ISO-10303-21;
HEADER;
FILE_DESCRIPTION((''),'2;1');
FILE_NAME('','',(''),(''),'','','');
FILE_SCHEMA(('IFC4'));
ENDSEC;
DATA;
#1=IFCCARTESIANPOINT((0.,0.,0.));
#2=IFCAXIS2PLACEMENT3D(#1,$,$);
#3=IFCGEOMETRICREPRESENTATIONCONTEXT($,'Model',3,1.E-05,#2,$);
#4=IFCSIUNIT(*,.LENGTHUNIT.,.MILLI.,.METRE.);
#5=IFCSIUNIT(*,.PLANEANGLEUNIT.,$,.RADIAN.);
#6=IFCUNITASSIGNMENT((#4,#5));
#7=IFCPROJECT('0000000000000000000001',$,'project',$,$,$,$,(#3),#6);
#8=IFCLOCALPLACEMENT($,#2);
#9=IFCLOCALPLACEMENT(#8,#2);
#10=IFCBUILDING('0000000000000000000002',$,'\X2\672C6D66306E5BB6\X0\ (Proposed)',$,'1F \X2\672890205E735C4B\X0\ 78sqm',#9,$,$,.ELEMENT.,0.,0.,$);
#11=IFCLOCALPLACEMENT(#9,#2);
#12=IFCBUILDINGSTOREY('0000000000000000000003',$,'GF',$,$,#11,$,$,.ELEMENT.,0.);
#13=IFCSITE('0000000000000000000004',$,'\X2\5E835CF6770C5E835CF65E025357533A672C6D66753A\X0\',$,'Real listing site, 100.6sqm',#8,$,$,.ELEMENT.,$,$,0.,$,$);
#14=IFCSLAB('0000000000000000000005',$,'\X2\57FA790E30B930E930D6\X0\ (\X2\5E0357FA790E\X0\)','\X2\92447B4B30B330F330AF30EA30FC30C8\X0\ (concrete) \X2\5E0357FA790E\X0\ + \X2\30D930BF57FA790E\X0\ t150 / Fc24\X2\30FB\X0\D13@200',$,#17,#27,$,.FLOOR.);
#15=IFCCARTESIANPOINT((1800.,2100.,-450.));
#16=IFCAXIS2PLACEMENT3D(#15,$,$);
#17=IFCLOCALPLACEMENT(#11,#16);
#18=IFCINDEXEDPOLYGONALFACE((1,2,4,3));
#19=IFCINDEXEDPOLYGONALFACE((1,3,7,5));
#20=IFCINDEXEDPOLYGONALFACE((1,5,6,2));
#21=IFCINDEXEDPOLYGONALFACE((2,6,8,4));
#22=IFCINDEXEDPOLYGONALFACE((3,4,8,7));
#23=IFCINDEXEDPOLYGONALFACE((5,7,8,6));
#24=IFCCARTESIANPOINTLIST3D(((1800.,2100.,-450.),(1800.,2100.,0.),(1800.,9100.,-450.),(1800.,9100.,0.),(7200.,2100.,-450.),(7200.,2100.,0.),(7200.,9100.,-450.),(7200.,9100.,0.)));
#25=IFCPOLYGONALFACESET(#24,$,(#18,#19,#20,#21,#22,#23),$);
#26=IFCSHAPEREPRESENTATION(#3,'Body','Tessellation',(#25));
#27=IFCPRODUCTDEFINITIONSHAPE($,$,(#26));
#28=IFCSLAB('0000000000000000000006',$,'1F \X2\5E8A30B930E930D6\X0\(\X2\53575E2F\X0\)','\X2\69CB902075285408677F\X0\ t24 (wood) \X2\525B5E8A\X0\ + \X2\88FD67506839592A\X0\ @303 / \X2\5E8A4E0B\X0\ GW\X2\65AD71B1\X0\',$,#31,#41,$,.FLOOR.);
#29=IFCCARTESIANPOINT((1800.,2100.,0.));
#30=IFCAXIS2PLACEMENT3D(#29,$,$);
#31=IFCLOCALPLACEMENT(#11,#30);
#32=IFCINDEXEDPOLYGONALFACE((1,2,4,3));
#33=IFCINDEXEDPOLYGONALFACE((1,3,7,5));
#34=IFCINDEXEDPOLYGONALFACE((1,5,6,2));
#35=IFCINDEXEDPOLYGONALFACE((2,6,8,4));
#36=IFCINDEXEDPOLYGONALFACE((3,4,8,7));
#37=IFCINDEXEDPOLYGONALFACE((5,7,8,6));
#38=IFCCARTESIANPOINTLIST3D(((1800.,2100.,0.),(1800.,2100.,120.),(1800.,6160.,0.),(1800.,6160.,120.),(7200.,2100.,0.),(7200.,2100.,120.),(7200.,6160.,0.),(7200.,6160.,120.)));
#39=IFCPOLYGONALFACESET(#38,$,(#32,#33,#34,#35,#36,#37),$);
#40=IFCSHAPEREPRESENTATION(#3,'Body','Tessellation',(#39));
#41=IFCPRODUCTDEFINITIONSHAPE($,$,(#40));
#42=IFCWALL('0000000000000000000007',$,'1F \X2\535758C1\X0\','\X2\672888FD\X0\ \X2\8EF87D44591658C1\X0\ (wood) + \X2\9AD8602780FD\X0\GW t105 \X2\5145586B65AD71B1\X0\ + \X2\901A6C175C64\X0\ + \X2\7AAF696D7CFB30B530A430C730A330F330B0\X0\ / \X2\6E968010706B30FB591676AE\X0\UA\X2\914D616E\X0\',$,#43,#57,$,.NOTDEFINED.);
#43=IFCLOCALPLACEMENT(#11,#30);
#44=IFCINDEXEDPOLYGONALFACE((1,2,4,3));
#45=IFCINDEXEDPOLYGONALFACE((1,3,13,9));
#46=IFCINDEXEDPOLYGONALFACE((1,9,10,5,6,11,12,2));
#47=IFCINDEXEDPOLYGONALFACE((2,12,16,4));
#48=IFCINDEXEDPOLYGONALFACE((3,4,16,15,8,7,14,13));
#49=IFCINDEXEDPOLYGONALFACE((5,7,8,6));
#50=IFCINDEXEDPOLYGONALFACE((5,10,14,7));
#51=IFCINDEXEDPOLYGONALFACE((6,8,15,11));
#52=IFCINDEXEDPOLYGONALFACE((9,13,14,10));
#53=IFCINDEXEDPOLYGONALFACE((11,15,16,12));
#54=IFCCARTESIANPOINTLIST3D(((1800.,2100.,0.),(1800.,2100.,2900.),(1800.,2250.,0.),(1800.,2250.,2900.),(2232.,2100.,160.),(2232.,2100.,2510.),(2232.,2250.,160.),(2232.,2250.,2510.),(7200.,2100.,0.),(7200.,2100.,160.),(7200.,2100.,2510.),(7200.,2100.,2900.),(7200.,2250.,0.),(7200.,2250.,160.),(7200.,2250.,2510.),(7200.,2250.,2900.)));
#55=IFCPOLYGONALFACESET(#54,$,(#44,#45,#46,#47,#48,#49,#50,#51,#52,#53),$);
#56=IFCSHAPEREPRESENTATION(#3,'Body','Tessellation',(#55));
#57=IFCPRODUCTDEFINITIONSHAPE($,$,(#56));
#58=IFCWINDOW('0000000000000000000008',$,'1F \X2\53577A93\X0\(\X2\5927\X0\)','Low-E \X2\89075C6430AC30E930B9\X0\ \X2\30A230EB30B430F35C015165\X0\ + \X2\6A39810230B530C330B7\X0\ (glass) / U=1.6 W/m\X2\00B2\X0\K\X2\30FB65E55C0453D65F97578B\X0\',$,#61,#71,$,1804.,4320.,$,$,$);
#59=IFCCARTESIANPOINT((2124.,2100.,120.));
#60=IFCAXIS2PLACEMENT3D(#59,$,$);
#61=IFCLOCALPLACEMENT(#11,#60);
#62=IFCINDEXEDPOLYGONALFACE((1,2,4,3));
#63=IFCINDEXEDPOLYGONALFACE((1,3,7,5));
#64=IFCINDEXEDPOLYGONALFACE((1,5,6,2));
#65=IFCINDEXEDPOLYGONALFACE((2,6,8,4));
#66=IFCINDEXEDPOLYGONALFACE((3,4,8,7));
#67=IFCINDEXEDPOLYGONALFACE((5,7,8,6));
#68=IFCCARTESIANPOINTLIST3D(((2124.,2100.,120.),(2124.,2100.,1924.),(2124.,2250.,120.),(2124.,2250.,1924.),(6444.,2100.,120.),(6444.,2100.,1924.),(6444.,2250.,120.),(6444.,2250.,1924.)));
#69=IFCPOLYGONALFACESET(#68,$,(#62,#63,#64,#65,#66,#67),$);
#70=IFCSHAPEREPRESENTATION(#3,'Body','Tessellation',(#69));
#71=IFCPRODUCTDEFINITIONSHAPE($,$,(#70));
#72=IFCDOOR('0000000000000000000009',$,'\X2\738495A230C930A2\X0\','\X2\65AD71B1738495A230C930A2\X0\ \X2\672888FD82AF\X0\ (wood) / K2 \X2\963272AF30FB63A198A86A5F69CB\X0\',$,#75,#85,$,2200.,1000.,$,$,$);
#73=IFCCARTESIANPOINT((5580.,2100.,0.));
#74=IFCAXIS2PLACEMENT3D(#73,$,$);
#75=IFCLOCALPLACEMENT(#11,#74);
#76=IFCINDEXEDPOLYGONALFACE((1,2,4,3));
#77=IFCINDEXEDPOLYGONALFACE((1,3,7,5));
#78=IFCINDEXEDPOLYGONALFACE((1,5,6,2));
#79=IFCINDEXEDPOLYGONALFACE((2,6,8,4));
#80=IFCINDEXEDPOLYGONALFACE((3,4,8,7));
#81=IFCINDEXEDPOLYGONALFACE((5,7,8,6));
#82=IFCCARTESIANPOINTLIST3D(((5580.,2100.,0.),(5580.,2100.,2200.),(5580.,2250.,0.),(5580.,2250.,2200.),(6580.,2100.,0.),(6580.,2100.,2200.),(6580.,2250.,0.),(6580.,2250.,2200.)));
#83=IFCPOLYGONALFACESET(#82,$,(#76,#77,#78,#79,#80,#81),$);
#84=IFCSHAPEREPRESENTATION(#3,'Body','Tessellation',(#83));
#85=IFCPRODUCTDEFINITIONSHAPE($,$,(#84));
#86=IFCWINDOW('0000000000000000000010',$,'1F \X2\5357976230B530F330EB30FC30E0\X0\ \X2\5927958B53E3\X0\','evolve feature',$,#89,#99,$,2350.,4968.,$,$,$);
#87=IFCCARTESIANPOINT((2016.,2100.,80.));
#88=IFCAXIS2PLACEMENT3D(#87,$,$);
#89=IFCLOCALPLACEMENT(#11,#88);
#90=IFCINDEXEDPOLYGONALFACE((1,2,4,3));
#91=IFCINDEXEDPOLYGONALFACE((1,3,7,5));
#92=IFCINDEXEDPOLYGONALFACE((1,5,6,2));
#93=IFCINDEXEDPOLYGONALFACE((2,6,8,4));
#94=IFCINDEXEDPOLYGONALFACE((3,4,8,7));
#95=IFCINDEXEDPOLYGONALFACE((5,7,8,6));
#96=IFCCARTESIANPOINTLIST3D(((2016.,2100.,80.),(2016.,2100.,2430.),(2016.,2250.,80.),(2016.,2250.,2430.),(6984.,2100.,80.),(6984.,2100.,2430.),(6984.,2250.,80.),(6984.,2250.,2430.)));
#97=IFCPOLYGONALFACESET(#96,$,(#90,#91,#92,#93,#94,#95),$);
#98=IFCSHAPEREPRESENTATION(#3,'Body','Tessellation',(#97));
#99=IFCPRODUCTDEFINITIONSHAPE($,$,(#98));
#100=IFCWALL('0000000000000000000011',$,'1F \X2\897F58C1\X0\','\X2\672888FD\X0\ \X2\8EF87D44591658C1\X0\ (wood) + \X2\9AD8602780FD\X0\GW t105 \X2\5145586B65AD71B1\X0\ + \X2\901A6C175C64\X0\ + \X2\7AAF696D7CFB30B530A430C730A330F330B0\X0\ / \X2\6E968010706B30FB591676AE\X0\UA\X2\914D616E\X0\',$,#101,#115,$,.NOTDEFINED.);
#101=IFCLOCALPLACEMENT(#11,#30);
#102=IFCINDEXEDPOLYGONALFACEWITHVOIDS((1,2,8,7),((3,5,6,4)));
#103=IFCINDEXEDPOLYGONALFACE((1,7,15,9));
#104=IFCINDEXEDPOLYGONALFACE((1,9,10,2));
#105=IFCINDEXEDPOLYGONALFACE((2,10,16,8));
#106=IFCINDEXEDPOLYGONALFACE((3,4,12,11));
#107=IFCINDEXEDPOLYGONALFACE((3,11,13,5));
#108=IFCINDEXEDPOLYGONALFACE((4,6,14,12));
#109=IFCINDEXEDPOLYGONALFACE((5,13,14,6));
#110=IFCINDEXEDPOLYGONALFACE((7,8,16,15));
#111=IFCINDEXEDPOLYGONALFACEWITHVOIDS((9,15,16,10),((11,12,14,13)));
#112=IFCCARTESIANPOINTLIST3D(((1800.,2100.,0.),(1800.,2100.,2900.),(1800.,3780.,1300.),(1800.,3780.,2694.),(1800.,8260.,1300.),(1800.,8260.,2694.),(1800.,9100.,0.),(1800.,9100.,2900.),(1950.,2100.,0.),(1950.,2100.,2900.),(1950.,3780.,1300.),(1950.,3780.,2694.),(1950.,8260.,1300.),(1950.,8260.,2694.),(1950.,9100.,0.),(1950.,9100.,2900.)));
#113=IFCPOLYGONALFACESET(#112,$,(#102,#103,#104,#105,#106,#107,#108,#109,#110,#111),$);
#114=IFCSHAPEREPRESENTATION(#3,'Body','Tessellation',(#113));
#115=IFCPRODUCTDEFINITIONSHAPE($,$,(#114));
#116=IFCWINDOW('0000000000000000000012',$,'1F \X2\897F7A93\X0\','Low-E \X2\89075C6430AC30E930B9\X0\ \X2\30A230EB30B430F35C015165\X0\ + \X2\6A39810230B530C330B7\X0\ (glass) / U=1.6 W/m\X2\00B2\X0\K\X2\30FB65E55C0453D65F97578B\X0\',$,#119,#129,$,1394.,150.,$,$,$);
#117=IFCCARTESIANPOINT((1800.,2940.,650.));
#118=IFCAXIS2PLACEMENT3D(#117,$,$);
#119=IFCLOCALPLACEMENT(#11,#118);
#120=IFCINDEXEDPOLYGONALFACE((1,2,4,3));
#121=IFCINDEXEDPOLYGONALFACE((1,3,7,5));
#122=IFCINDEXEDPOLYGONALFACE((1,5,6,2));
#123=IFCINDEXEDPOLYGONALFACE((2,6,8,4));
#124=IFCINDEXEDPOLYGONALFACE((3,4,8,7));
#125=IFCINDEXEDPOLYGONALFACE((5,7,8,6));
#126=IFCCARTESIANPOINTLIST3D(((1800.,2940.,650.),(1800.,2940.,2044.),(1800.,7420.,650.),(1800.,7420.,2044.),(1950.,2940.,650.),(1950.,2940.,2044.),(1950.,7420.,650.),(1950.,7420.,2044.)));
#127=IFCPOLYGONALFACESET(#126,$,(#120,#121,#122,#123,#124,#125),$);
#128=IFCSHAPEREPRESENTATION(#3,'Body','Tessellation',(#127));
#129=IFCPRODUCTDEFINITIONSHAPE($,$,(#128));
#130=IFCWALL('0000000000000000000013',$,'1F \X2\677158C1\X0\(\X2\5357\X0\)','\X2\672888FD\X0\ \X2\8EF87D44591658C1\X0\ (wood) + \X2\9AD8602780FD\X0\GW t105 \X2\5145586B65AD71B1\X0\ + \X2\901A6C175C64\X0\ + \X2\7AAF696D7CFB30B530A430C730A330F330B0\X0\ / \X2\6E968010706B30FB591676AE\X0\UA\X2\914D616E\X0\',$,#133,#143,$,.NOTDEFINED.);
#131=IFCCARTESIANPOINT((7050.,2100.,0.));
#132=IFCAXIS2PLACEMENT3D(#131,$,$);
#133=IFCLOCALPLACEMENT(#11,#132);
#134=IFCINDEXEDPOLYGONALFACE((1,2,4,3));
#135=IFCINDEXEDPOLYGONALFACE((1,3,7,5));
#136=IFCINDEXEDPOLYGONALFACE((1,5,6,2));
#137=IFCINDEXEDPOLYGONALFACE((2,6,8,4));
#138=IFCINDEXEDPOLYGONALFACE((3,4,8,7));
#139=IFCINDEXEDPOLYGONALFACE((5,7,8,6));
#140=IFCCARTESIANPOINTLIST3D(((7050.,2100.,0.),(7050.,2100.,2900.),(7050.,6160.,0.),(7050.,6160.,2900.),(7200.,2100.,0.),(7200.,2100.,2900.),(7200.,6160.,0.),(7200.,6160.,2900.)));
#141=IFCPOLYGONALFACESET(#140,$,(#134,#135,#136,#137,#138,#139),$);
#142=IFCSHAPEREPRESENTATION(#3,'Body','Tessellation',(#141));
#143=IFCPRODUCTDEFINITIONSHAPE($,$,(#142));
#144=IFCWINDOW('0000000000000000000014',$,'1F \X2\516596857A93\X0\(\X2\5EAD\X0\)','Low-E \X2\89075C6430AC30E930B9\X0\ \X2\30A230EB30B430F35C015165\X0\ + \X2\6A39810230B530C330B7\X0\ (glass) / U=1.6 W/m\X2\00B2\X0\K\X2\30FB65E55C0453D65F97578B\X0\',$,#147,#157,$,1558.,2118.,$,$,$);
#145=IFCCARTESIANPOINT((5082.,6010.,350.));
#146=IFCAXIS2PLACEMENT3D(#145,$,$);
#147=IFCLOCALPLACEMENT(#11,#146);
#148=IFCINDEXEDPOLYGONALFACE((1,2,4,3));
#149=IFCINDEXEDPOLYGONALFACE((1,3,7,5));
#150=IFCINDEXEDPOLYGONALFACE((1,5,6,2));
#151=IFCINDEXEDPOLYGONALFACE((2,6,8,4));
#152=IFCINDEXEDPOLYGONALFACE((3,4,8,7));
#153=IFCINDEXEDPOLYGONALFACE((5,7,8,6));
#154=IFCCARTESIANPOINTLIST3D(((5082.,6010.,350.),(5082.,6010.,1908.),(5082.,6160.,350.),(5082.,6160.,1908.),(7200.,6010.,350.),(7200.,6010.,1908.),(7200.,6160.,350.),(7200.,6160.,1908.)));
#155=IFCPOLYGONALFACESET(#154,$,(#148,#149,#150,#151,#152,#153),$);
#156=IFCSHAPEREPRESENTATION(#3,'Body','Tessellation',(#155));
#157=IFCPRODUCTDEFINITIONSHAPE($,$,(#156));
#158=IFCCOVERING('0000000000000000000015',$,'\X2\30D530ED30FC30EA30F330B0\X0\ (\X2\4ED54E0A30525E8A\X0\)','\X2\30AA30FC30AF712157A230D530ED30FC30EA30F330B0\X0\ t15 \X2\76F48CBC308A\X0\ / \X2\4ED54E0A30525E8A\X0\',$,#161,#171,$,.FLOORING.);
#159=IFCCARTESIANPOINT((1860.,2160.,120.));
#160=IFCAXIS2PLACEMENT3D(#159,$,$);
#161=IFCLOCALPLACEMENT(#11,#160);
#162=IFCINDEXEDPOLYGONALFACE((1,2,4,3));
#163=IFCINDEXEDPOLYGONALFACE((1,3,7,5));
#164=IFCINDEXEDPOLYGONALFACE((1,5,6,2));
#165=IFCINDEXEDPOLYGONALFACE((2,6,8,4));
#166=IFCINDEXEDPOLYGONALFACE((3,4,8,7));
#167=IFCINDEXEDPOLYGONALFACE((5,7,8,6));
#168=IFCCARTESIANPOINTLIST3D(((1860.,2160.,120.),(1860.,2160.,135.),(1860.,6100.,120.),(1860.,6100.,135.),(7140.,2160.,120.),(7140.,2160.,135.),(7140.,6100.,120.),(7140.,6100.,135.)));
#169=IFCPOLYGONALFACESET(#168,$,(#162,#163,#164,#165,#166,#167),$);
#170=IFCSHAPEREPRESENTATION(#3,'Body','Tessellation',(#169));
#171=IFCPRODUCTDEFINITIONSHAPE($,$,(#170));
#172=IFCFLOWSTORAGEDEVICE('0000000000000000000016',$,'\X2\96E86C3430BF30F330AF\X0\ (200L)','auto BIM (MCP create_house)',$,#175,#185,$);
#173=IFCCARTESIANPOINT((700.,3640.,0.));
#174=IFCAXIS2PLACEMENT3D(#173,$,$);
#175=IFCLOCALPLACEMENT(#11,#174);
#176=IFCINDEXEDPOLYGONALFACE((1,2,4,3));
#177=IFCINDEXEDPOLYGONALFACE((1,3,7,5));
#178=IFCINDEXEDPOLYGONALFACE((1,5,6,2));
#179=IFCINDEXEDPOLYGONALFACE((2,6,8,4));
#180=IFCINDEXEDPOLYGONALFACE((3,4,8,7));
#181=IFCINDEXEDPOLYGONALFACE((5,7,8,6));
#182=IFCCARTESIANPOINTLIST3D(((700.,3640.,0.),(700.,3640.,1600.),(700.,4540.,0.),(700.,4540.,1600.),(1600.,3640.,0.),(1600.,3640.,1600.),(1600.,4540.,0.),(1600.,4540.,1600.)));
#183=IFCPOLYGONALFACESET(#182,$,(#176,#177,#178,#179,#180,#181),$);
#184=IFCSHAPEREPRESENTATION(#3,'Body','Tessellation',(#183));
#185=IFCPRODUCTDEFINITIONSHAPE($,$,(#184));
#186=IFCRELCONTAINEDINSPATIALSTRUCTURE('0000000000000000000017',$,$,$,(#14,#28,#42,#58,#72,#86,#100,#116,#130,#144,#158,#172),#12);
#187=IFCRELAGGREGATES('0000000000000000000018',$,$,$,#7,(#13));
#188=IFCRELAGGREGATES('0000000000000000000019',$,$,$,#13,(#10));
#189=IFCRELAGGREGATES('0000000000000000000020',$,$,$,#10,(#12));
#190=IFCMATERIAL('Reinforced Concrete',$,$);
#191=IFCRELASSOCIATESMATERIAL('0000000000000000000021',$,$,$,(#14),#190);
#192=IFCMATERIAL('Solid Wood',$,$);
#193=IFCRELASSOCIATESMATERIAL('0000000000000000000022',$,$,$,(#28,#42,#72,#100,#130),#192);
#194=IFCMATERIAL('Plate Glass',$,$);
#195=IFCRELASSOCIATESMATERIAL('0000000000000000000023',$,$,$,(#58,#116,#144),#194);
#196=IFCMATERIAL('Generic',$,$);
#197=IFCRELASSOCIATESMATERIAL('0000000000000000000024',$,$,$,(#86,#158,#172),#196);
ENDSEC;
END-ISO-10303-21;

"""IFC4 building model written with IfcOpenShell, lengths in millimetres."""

from ifc_helpers import new_model, si_unit, frame, frame_2d, origin, place, context, project, spatial, rectangle, extrude, material, element, fill, save


model = new_model("IFC4")

# Units and contexts
model_context = context("Model", 3, precision=1e-05, world=origin())
ifc_project = project(units=[si_unit("LENGTHUNIT", "METRE", prefix="MILLI"), si_unit("PLANEANGLEUNIT", "RADIAN")], contexts=[model_context])

# Site, building, storey
site_placement = place(None, origin())
site = spatial("IfcSite", under=ifc_project, at=site_placement, Name="広島県広島市南区本浦町", ObjectType="Real listing site, 100.6sqm", CompositionType="ELEMENT", RefElevation=0.0)
building_placement = place(site_placement, origin())
building = spatial("IfcBuilding", under=site, at=building_placement, Name="本浦の家 (Proposed)", ObjectType="1F 木造平屋 78sqm", CompositionType="ELEMENT", ElevationOfRefHeight=0.0, ElevationOfTerrain=0.0)
storey_placement = place(building_placement, origin())
storey = spatial("IfcBuildingStorey", under=building, at=storey_placement, Name="GF", CompositionType="ELEMENT", Elevation=0.0)

# Slabs
ifc_material_1 = material(Name="Reinforced Concrete")
slab_1_placement = place(storey_placement, frame((1800.0, 2100.0, -450.0)))
element("IfcSlab", 1, at=slab_1_placement, inside=storey, material=ifc_material_1, Name="基礎スラブ (布基礎)", Description="鉄筋コンクリート (concrete) 布基礎 + ベタ基礎 t150 / Fc24・D13@200", PredefinedType="FLOOR", context=model_context, shape_type="SweptSolid", body=[
    extrude(rectangle(XDim=5400.0, YDim=7000.0, at=frame_2d((2700.0, 3500.0))), frame((1800.0, 2100.0, -450.0)), (0.0, 0.0, 1.0), 450.0),
])
ifc_material_2 = material(Name="Solid Wood")
slab_2_placement = place(storey_placement, frame((1800.0, 2100.0, 0.0)))
element("IfcSlab", 2, at=slab_2_placement, inside=storey, material=ifc_material_2, Name="1F 床スラブ(南帯)", Description="構造用合板 t24 (wood) 剛床 + 製材根太 @303 / 床下 GW断熱", PredefinedType="FLOOR", context=model_context, shape_type="SweptSolid", body=[
    extrude(rectangle(XDim=5400.0, YDim=4060.0, at=frame_2d((2700.0, 2030.0))), frame((1800.0, 2100.0, 0.0)), (0.0, 0.0, 1.0), 120.0),
])

# Wall, openings, windows, door
wall_1_placement = place(storey_placement, frame((1800.0, 2100.0, 0.0)))
wall_1 = element("IfcWall", 3, at=wall_1_placement, inside=storey, material=ifc_material_2, Name="1F 南壁", Description="木製 軸組外壁 (wood) + 高性能GW t105 充填断熱 + 通気層 + 窯業系サイディング / 準耐火・外皮UA配慮", PredefinedType="NOTDEFINED", context=model_context, shape_type="SweptSolid", body=[
    extrude(rectangle(XDim=5400.0, YDim=150.0, at=frame_2d((2700.0, 75.0))), frame((1800.0, 2100.0, 0.0)), (0.0, 0.0, 1.0), 2900.0),
])
opening_1_placement = place(storey_placement, frame((2124.0, 2100.0, 120.0)))
opening_1 = element("IfcOpeningElement", 4, at=opening_1_placement, cuts=wall_1, PredefinedType="NOTDEFINED", context=model_context, shape_type="SweptSolid", body=[
    extrude(rectangle(XDim=4320.0, YDim=150.0, at=frame_2d((2160.0, 75.0))), frame((2124.0, 2100.0, 120.0)), (0.0, 0.0, 1.0), 1804.0),
])
opening_2_placement = place(storey_placement, frame((5580.0, 2100.0, 0.0)))
opening_2 = element("IfcOpeningElement", 5, at=opening_2_placement, cuts=wall_1, PredefinedType="NOTDEFINED", context=model_context, shape_type="SweptSolid", body=[
    extrude(rectangle(XDim=1000.0, YDim=150.0, at=frame_2d((500.0, 75.0))), frame((5580.0, 2100.0, 0.0)), (0.0, 0.0, 1.0), 2200.0),
])
opening_3_placement = place(storey_placement, frame((2016.0, 2100.0, 80.0)))
opening_3 = element("IfcOpeningElement", 6, at=opening_3_placement, cuts=wall_1, PredefinedType="NOTDEFINED", context=model_context, shape_type="SweptSolid", body=[
    extrude(rectangle(XDim=4968.0, YDim=150.0, at=frame_2d((2484.0, 75.0))), frame((2016.0, 2100.0, 80.0)), (0.0, 0.0, 1.0), 2350.0),
])
ifc_material_3 = material(Name="Plate Glass")
window_1_placement = place(storey_placement, frame((2124.0, 2100.0, 120.0)))
window_1 = element("IfcWindow", 7, at=window_1_placement, inside=storey, material=ifc_material_3, Name="1F 南窓(大)", Description="Low-E 複層ガラス アルゴン封入 + 樹脂サッシ (glass) / U=1.6 W/m²K・日射取得型", OverallHeight=1804.0, OverallWidth=4320.0, context=model_context, shape_type="SweptSolid", body=[
    extrude(rectangle(XDim=4320.0, YDim=150.0, at=frame_2d((2160.0, 75.0))), frame((2124.0, 2100.0, 120.0)), (0.0, 0.0, 1.0), 1804.0),
])
fill(opening_1, window_1)
door_1_placement = place(storey_placement, frame((5580.0, 2100.0, 0.0)))
door_1 = element("IfcDoor", 8, at=door_1_placement, inside=storey, material=ifc_material_2, Name="玄関ドア", Description="断熱玄関ドア 木製芯 (wood) / K2 防犯・採風機構", OverallHeight=2200.0, OverallWidth=1000.0, context=model_context, shape_type="SweptSolid", body=[
    extrude(rectangle(XDim=1000.0, YDim=150.0, at=frame_2d((500.0, 75.0))), frame((5580.0, 2100.0, 0.0)), (0.0, 0.0, 1.0), 2200.0),
])
fill(opening_2, door_1)
ifc_material_4 = material(Name="Generic")
window_2_placement = place(storey_placement, frame((2016.0, 2100.0, 80.0)))
window_2 = element("IfcWindow", 9, at=window_2_placement, inside=storey, material=ifc_material_4, Name="1F 南面サンルーム 大開口", Description="evolve feature", OverallHeight=2350.0, OverallWidth=4968.0, context=model_context, shape_type="SweptSolid", body=[
    extrude(rectangle(XDim=4968.0, YDim=150.0, at=frame_2d((2484.0, 75.0))), frame((2016.0, 2100.0, 80.0)), (0.0, 0.0, 1.0), 2350.0),
])
fill(opening_3, window_2)

# Walls, openings, windows
wall_2_placement = place(storey_placement, frame((1800.0, 2100.0, 0.0)))
wall_2 = element("IfcWall", 10, at=wall_2_placement, inside=storey, material=ifc_material_2, Name="1F 西壁", Description="木製 軸組外壁 (wood) + 高性能GW t105 充填断熱 + 通気層 + 窯業系サイディング / 準耐火・外皮UA配慮", PredefinedType="NOTDEFINED", context=model_context, shape_type="SweptSolid", body=[
    extrude(rectangle(XDim=150.0, YDim=7000.0, at=frame_2d((75.0, 3500.0))), frame((1800.0, 2100.0, 0.0)), (0.0, 0.0, 1.0), 2900.0),
])
opening_4_placement = place(storey_placement, frame((1800.0, 2940.0, 650.0)))
opening_4 = element("IfcOpeningElement", 11, at=opening_4_placement, cuts=wall_2, PredefinedType="NOTDEFINED", context=model_context, shape_type="SweptSolid", body=[
    extrude(rectangle(XDim=150.0, YDim=4480.0, at=frame_2d((75.0, 2240.0))), frame((1800.0, 2940.0, 650.0)), (0.0, 0.0, 1.0), 1394.0),
])
window_3_placement = place(storey_placement, frame((1800.0, 2940.0, 650.0)))
window_3 = element("IfcWindow", 12, at=window_3_placement, inside=storey, material=ifc_material_3, Name="1F 西窓", Description="Low-E 複層ガラス アルゴン封入 + 樹脂サッシ (glass) / U=1.6 W/m²K・日射取得型", OverallHeight=1394.0, OverallWidth=150.0, context=model_context, shape_type="SweptSolid", body=[
    extrude(rectangle(XDim=150.0, YDim=4480.0, at=frame_2d((75.0, 2240.0))), frame((1800.0, 2940.0, 650.0)), (0.0, 0.0, 1.0), 1394.0),
])
fill(opening_4, window_3)
wall_3_placement = place(storey_placement, frame((7050.0, 2100.0, 0.0)))
wall_3 = element("IfcWall", 13, at=wall_3_placement, inside=storey, material=ifc_material_2, Name="1F 東壁(南)", Description="木製 軸組外壁 (wood) + 高性能GW t105 充填断熱 + 通気層 + 窯業系サイディング / 準耐火・外皮UA配慮", PredefinedType="NOTDEFINED", context=model_context, shape_type="SweptSolid", body=[
    extrude(rectangle(XDim=150.0, YDim=4060.0, at=frame_2d((75.0, 2030.0))), frame((7050.0, 2100.0, 0.0)), (0.0, 0.0, 1.0), 2900.0),
])
opening_5_placement = place(storey_placement, frame((5082.0, 6010.0, 350.0)))
opening_5 = element("IfcOpeningElement", 14, at=opening_5_placement, cuts=wall_3, PredefinedType="NOTDEFINED", context=model_context, shape_type="SweptSolid", body=[
    extrude(rectangle(XDim=2118.0, YDim=150.0, at=frame_2d((1059.0, 75.0))), frame((5082.0, 6010.0, 350.0)), (0.0, 0.0, 1.0), 1558.0),
])
window_4_placement = place(storey_placement, frame((5082.0, 6010.0, 350.0)))
window_4 = element("IfcWindow", 15, at=window_4_placement, inside=storey, material=ifc_material_3, Name="1F 入隅窓(庭)", Description="Low-E 複層ガラス アルゴン封入 + 樹脂サッシ (glass) / U=1.6 W/m²K・日射取得型", OverallHeight=1558.0, OverallWidth=2118.0, context=model_context, shape_type="SweptSolid", body=[
    extrude(rectangle(XDim=2118.0, YDim=150.0, at=frame_2d((1059.0, 75.0))), frame((5082.0, 6010.0, 350.0)), (0.0, 0.0, 1.0), 1558.0),
])
fill(opening_5, window_4)

# Covering
covering_placement = place(storey_placement, frame((1860.0, 2160.0, 120.0)))
element("IfcCovering", 16, at=covering_placement, inside=storey, material=ifc_material_4, Name="フローリング (仕上げ床)", Description="オーク無垢フローリング t15 直貼り / 仕上げ床", PredefinedType="FLOORING", context=model_context, shape_type="SweptSolid", body=[
    extrude(rectangle(XDim=5280.0, YDim=3940.0, at=frame_2d((2640.0, 1970.0))), frame((1860.0, 2160.0, 120.0)), (0.0, 0.0, 1.0), 15.0),
])

# Flow storage device
flow_storage_device_placement = place(storey_placement, frame((700.0, 3640.0, 0.0)))
element("IfcFlowStorageDevice", 17, at=flow_storage_device_placement, inside=storey, material=ifc_material_4, Name="雨水タンク (200L)", Description="auto BIM (MCP create_house)", context=model_context, shape_type="SweptSolid", body=[
    extrude(rectangle(XDim=900.0, YDim=900.0, at=frame_2d((450.0, 450.0))), frame((700.0, 3640.0, 0.0)), (0.0, 0.0, 1.0), 1600.0),
])

save(model, "model.ifc")
